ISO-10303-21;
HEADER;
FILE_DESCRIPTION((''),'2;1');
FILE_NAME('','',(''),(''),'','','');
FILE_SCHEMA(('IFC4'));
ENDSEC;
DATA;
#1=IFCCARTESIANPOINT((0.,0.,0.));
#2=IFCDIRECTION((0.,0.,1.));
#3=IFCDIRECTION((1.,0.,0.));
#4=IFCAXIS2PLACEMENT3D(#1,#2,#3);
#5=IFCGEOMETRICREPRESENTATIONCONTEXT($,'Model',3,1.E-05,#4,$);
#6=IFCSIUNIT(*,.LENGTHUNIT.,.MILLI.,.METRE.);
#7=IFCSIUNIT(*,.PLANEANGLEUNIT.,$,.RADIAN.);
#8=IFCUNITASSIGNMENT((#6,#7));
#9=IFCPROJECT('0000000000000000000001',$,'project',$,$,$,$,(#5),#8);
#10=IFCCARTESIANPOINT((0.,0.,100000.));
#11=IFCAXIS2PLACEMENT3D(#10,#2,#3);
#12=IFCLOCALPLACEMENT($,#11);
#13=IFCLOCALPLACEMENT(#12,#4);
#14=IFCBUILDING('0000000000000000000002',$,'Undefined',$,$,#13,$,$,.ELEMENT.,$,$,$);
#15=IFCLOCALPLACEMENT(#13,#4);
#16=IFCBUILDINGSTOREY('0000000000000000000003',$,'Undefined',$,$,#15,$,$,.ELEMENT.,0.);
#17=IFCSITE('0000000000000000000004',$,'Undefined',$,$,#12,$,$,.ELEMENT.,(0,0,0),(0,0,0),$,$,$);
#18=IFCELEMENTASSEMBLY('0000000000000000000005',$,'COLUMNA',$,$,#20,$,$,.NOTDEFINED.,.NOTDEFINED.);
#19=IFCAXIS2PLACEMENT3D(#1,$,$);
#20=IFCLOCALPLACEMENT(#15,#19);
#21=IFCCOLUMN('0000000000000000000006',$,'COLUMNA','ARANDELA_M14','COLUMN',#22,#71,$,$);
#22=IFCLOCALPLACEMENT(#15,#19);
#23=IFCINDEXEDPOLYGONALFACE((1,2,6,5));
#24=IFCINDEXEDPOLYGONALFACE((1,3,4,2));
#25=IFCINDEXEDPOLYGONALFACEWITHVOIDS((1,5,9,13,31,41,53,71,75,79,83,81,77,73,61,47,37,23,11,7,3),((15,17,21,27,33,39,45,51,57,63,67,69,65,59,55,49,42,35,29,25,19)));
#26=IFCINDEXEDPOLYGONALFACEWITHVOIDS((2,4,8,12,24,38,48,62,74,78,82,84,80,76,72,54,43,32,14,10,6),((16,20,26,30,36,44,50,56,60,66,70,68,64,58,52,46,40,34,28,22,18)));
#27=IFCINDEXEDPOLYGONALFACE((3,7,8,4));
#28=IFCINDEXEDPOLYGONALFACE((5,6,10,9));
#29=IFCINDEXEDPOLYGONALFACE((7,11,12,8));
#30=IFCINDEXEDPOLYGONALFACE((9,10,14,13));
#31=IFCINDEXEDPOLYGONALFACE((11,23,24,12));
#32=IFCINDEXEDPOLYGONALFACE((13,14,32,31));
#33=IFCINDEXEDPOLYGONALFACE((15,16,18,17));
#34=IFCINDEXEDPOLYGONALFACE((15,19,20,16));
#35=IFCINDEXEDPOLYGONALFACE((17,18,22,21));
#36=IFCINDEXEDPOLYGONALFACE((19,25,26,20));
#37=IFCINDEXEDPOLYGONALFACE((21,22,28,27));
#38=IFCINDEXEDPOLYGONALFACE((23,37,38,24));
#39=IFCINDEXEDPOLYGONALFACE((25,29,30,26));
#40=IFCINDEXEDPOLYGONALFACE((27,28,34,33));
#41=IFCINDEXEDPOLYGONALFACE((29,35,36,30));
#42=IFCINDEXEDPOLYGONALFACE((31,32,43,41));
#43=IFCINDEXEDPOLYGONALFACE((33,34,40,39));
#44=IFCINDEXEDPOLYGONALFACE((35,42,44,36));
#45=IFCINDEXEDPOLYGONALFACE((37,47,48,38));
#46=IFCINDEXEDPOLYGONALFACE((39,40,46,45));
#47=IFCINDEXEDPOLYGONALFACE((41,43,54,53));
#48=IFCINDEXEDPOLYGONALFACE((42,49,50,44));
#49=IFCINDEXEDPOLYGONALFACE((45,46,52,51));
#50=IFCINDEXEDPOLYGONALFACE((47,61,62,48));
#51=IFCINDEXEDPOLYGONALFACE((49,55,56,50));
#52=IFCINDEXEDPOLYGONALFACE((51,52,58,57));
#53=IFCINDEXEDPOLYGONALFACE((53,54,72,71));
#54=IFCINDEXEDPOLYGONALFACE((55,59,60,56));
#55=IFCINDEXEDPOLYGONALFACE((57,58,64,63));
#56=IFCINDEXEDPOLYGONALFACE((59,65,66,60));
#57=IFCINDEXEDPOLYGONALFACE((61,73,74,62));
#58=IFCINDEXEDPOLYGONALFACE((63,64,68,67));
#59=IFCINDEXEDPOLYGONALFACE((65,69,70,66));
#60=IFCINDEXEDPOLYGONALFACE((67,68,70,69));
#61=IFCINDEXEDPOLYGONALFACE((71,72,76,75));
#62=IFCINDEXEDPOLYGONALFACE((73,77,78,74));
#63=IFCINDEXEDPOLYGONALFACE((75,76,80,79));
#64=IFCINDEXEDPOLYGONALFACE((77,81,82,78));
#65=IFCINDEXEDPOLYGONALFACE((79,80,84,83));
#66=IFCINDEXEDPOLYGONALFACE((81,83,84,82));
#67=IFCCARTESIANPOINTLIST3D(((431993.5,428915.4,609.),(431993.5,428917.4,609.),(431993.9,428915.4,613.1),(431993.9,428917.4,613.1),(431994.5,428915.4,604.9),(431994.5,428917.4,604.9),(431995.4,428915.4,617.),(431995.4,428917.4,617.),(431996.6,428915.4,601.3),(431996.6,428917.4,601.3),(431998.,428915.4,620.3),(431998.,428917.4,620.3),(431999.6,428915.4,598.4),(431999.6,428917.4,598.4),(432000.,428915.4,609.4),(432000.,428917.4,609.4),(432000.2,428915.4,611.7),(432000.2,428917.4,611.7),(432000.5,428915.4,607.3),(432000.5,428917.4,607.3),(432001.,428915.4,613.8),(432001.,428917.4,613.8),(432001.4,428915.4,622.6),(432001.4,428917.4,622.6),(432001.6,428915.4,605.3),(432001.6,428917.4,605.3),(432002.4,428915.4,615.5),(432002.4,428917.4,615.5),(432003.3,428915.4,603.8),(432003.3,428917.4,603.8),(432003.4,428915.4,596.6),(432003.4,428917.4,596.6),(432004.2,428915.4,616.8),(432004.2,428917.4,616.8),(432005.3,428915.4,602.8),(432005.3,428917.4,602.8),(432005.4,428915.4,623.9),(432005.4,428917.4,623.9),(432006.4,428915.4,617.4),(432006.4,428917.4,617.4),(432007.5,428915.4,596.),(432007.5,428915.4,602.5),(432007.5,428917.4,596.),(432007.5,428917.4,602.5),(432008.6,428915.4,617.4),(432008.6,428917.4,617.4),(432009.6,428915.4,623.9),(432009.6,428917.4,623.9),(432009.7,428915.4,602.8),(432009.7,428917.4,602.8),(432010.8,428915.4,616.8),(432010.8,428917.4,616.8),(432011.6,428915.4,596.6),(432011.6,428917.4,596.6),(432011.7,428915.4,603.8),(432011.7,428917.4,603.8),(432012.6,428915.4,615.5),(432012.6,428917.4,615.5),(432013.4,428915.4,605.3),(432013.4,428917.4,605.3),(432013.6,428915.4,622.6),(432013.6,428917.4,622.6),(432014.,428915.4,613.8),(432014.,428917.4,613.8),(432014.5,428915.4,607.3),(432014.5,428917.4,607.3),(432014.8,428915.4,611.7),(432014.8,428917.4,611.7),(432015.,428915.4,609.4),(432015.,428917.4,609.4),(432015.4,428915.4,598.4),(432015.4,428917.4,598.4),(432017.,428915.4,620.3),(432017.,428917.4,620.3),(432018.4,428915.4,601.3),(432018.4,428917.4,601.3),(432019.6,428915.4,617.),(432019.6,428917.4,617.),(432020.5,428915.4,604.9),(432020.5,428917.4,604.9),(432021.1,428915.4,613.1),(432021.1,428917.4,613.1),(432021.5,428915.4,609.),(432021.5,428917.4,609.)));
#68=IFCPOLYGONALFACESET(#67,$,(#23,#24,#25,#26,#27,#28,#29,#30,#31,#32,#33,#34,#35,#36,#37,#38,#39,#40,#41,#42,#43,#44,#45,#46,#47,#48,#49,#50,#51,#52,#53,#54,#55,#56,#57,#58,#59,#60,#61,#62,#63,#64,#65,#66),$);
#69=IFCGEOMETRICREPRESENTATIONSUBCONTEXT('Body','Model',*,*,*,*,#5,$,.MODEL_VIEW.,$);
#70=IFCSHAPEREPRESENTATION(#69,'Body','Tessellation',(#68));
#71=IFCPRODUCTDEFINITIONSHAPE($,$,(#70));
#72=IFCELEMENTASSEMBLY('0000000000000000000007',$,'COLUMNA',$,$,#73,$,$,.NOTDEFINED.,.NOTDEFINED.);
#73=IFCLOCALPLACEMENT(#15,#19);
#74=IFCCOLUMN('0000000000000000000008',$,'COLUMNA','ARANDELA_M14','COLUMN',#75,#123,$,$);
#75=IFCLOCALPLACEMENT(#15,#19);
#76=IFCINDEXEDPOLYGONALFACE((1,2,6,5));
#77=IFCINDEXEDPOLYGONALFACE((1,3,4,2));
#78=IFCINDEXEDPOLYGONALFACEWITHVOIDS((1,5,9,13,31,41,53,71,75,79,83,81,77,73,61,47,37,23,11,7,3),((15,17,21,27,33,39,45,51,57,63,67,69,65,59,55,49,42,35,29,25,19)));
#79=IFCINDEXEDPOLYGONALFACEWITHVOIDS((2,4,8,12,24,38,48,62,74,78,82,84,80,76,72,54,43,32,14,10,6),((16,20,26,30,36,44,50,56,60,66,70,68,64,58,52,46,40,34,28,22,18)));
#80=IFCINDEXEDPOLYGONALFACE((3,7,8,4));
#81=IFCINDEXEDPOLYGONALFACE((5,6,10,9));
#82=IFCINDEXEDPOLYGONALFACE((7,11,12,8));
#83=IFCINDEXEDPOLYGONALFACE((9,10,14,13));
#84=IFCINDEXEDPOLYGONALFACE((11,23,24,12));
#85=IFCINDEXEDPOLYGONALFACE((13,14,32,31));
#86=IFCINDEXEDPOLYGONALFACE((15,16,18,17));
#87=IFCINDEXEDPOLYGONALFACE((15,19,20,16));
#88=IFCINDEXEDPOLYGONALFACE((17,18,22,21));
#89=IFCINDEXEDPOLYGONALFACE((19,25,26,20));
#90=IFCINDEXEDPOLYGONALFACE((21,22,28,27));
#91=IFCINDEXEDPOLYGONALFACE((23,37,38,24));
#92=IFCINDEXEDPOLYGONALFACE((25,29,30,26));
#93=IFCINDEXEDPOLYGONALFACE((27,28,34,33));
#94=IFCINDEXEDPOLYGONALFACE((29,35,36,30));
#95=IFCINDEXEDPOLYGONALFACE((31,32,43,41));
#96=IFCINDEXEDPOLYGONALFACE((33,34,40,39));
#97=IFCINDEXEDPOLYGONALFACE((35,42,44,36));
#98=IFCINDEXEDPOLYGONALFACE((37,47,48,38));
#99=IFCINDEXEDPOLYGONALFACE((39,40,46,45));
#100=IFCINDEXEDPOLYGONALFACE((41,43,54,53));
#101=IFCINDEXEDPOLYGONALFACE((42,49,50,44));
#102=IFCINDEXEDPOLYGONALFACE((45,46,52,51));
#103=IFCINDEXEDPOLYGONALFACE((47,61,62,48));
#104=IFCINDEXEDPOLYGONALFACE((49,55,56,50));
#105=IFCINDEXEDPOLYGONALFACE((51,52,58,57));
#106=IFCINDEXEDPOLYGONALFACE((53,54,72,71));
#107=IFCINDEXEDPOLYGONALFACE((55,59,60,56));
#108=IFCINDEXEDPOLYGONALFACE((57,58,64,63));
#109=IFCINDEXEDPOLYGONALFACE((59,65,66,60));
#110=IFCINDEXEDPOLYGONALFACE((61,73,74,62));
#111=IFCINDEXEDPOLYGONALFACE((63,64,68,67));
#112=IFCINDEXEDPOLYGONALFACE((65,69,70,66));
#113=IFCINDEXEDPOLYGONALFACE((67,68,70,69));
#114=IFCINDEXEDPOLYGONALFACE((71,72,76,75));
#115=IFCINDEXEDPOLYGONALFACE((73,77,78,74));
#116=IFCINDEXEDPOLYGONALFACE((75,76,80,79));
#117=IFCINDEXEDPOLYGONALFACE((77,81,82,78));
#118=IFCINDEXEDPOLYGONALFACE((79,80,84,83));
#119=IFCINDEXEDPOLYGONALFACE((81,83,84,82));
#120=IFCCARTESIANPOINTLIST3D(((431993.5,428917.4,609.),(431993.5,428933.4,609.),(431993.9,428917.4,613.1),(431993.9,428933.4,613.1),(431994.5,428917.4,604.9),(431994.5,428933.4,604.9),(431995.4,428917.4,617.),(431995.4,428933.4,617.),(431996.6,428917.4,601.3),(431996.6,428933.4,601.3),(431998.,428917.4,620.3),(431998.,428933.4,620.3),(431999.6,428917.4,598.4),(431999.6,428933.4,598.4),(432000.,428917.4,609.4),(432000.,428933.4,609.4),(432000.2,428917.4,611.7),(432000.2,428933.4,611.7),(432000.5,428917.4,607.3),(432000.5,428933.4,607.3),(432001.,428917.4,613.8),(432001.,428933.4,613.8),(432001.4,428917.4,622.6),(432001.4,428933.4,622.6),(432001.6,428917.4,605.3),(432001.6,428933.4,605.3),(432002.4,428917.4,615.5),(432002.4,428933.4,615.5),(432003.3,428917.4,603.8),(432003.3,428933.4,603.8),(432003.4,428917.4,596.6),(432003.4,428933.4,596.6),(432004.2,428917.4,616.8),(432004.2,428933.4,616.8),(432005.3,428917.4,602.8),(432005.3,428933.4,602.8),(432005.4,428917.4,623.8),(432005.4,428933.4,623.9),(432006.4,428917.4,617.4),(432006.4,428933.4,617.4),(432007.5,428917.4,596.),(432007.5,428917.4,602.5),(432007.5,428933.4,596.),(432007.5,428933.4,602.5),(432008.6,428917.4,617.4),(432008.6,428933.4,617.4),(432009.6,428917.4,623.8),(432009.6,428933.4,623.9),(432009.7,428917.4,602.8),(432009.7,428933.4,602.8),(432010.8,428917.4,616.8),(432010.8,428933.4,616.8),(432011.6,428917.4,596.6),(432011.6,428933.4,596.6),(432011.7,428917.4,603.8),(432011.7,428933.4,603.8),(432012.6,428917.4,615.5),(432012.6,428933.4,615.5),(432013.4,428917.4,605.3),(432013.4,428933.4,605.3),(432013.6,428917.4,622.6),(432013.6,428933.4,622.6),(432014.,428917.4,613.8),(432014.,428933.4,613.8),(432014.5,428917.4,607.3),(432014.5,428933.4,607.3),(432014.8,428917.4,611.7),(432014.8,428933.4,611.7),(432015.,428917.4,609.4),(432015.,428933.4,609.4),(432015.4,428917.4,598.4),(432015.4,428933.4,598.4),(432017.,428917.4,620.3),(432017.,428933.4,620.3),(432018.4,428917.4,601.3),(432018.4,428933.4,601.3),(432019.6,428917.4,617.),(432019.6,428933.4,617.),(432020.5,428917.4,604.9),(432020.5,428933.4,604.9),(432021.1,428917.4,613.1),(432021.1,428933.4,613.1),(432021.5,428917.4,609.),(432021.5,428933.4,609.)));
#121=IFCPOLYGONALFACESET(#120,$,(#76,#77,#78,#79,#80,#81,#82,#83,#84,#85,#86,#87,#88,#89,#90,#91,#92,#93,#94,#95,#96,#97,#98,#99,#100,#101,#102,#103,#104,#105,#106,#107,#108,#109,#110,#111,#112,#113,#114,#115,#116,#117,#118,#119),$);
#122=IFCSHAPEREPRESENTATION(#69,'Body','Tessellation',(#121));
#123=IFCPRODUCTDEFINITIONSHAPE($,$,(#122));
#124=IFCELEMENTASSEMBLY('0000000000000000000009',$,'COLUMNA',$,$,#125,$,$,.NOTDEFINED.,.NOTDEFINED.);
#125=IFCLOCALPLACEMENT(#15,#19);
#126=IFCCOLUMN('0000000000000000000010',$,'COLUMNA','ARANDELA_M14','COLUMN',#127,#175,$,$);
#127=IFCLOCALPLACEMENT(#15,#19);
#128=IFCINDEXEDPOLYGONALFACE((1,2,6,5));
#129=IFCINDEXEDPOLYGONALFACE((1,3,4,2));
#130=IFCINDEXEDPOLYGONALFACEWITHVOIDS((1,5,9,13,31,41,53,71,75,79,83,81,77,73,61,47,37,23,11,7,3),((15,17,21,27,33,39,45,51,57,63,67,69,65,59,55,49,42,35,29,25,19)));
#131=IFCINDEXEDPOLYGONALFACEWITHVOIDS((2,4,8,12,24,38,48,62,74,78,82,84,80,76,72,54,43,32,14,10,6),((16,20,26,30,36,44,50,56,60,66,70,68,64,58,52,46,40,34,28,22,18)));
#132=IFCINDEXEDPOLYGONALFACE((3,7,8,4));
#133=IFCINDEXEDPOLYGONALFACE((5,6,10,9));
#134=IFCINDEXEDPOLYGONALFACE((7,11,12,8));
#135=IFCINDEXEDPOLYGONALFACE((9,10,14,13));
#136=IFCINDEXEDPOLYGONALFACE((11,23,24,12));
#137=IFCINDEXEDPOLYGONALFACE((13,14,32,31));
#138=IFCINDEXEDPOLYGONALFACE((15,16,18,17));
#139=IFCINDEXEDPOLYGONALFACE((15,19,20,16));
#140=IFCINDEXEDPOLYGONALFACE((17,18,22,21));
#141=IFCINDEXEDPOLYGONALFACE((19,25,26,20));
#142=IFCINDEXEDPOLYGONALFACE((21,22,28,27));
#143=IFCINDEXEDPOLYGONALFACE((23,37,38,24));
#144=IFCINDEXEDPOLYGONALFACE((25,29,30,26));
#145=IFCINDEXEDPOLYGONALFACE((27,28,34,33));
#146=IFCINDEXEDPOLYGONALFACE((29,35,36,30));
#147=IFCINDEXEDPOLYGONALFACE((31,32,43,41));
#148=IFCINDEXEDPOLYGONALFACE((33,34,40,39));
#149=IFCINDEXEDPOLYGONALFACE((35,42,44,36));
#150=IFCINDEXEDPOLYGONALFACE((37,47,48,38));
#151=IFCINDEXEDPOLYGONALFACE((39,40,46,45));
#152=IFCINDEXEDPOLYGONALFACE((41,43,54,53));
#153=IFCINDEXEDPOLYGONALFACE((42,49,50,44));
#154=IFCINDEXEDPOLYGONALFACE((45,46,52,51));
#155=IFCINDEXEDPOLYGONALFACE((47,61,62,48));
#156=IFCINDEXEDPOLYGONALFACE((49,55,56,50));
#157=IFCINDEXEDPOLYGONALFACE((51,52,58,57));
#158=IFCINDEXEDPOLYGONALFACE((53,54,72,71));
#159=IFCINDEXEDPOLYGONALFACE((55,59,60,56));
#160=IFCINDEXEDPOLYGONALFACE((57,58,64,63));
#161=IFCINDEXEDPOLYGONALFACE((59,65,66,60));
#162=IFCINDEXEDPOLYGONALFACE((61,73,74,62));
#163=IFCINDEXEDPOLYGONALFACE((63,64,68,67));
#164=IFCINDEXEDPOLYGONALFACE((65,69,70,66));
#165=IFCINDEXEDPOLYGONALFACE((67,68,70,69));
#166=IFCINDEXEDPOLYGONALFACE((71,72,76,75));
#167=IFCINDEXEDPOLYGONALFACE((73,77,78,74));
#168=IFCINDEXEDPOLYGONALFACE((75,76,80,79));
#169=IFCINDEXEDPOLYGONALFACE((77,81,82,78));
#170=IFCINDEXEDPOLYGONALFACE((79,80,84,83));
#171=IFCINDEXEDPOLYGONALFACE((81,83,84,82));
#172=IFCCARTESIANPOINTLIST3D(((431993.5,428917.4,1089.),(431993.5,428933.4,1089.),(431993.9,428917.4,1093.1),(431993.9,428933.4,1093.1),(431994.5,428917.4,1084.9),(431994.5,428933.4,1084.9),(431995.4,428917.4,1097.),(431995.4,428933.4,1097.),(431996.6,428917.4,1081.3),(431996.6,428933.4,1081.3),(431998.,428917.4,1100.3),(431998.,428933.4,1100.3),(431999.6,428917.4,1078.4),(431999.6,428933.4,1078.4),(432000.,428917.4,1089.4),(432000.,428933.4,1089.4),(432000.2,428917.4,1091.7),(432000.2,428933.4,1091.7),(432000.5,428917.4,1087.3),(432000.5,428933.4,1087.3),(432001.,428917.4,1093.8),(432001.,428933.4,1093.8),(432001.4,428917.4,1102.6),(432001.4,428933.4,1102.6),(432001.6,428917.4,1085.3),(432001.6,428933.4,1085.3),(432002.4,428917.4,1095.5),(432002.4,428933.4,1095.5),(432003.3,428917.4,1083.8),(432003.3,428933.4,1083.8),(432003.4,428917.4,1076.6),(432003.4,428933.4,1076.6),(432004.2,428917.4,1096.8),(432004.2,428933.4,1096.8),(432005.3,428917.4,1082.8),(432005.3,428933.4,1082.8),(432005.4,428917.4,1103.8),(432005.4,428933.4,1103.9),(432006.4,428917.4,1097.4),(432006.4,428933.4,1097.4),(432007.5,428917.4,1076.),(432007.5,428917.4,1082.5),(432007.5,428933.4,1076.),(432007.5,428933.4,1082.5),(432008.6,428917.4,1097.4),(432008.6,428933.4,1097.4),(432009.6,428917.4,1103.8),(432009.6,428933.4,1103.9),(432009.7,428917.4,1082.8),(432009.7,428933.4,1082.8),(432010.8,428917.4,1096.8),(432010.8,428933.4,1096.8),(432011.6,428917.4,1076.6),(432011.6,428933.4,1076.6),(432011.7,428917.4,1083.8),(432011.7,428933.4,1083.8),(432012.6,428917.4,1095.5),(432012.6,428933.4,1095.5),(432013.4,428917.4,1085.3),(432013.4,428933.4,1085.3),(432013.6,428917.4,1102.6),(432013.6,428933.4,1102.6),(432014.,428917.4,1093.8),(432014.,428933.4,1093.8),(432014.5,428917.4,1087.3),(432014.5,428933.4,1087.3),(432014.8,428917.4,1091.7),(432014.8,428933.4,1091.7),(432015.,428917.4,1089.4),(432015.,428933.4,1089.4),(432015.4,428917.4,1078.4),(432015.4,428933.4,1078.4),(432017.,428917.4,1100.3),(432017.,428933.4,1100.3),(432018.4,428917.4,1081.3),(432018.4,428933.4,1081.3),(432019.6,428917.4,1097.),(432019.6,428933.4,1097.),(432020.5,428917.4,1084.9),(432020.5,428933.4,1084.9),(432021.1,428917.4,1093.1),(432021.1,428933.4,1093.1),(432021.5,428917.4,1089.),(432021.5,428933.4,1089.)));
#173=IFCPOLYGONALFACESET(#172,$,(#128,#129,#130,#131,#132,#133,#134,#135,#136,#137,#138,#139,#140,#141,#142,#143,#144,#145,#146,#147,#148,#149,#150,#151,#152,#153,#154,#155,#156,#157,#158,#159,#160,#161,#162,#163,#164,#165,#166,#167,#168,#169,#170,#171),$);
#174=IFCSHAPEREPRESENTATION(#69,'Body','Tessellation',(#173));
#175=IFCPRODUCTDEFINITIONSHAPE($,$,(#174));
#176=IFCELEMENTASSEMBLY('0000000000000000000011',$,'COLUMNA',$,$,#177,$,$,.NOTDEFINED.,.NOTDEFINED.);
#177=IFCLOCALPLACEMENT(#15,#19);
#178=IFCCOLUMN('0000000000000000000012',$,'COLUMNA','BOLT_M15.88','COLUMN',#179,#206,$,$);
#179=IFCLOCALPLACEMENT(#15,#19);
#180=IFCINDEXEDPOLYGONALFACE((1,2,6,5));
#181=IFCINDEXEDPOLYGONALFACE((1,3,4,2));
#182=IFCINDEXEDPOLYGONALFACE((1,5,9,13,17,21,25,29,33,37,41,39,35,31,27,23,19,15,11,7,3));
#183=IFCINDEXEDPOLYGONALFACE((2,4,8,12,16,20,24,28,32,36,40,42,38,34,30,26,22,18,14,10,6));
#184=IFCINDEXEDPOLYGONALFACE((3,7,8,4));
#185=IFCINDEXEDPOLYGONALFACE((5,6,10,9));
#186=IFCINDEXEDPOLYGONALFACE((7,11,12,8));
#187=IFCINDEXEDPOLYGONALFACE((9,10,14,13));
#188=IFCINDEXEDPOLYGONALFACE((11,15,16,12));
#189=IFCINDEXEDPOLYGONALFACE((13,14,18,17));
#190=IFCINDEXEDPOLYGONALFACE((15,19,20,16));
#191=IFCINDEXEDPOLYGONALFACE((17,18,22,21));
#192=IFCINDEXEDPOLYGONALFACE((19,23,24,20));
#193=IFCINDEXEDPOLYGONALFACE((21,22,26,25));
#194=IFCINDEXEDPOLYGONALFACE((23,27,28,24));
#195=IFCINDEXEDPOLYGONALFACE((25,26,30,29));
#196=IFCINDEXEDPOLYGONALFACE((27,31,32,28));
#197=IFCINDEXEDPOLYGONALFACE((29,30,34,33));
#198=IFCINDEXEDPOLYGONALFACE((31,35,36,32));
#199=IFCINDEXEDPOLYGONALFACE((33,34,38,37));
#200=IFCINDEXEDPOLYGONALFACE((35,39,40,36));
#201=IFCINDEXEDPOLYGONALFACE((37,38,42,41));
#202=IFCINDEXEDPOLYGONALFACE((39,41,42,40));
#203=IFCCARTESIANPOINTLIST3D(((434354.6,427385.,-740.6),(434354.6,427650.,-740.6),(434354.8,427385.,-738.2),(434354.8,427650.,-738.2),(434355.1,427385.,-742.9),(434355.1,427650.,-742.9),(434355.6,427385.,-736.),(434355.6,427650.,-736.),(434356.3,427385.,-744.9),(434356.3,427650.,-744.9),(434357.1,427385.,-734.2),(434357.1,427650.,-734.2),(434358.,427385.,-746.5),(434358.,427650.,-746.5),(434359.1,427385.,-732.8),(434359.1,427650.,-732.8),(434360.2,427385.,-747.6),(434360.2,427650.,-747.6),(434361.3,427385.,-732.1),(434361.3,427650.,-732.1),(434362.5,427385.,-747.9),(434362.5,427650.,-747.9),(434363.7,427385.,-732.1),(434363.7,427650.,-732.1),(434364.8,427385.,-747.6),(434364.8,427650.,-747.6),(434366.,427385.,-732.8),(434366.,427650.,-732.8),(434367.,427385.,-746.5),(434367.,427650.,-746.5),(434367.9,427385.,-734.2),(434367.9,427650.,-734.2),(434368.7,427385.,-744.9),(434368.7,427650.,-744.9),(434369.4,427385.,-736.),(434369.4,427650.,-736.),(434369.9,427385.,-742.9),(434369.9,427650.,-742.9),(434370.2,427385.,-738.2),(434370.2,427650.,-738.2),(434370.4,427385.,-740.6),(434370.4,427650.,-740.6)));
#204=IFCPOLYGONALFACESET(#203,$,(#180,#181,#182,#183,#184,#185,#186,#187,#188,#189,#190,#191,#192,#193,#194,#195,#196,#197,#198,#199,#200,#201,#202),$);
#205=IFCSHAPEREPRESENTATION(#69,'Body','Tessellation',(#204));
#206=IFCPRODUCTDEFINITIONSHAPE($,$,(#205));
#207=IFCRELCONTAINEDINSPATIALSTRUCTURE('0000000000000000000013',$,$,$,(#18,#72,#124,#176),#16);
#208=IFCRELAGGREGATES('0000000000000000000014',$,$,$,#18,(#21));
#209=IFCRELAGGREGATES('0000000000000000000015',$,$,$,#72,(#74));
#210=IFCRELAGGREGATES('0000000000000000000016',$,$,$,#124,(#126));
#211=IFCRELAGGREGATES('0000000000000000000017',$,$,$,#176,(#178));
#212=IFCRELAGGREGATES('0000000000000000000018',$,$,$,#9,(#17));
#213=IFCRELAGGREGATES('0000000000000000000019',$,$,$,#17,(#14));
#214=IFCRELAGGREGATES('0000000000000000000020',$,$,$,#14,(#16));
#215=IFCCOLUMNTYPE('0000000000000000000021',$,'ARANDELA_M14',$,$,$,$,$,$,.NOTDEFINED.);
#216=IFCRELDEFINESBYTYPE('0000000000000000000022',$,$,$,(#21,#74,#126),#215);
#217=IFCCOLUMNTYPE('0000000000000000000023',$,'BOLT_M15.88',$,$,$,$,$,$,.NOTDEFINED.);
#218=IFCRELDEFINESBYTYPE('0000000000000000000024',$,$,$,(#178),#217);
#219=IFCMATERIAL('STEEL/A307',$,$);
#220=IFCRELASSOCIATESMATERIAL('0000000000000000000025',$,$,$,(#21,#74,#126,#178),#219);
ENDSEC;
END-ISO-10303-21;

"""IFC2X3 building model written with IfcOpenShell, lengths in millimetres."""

from ifc_helpers import new_model, si_unit, frame, origin_with_axes, origin_2d_with_axis, place, context, subcontext, project, spatial, circle, hollow_circle, extrude, material, type_object, element, aggregate, save


model = new_model("IFC2X3")

# Units and contexts
model_context = context("Model", 3, precision=1e-05, world=origin_with_axes())
body_context = subcontext(model_context, "Body", "Model", "MODEL_VIEW")
ifc_project = project(units=[si_unit("LENGTHUNIT", "METRE", prefix="MILLI"), si_unit("PLANEANGLEUNIT", "RADIAN")], contexts=[model_context])

# Site, building, storey
site_placement = place(None, frame((0.0, 0.0, 100000.0), z_axis=(0.0, 0.0, 1.0), x_axis=(1.0, 0.0, 0.0)))
site = spatial("IfcSite", under=ifc_project, at=site_placement, Name="Undefined", CompositionType="ELEMENT", RefLatitude=(0, 0, 0), RefLongitude=(0, 0, 0))
building_placement = place(site_placement, origin_with_axes())
building = spatial("IfcBuilding", under=site, at=building_placement, Name="Undefined", CompositionType="ELEMENT")
storey_placement = place(building_placement, origin_with_axes())
storey = spatial("IfcBuildingStorey", under=building, at=storey_placement, Name="Undefined", CompositionType="ELEMENT", Elevation=0.0)

# Element assemblies, columns
ifc_material_1 = material(Name="STEEL/A307")
column_type_1 = type_object("IfcColumnType", Name="ARANDELA_M14", PredefinedType="NOTDEFINED")
assembly_1_placement = place(storey_placement, origin_with_axes())
assembly_1 = element("IfcElementAssembly", 1, at=assembly_1_placement, inside=storey, Name="COLUMNA", AssemblyPlace="NOTDEFINED", PredefinedType="NOTDEFINED")
column_1_placement = place(assembly_1_placement, frame((432007.5, 428915.4, 610.0), z_axis=(0.0, 1.0, 0.000285), x_axis=(1.0, 0.0, 0.0)))
column_1 = element("IfcColumn", 2, at=column_1_placement, type_object=column_type_1, material=ifc_material_1, Name="COLUMNA", Description="ARANDELA_M14", ObjectType="COLUMN", context=body_context, shape_type="SweptSolid", body=[
    extrude(hollow_circle(Radius=14.0, WallThickness=6.5, at=origin_2d_with_axis()), frame((0.0, 0.0, 2.0), z_axis=(0.0, 0.0, -1.0), x_axis=(0.0, 1.0, 0.0)), (0.0, 0.0, 1.0), 2.0),
])
aggregate(assembly_1, [column_1])
assembly_2_placement = place(storey_placement, origin_with_axes())
assembly_2 = element("IfcElementAssembly", 3, at=assembly_2_placement, inside=storey, Name="COLUMNA", AssemblyPlace="NOTDEFINED", PredefinedType="NOTDEFINED")
column_2_placement = place(assembly_2_placement, frame((432007.5, 428917.4, 610.0), z_axis=(0.0, 1.0, 0.000285), x_axis=(1.0, 0.0, 0.0)))
column_2 = element("IfcColumn", 4, at=column_2_placement, type_object=column_type_1, material=ifc_material_1, Name="COLUMNA", Description="ARANDELA_M14", ObjectType="COLUMN", context=body_context, shape_type="SweptSolid", body=[
    extrude(hollow_circle(Radius=14.0, WallThickness=6.5, at=origin_2d_with_axis()), frame((0.0, 0.0, 16.0), z_axis=(0.0, 0.0, -1.0), x_axis=(0.0, 1.0, 0.0)), (0.0, 0.0, 1.0), 16.0),
])
aggregate(assembly_2, [column_2])
assembly_3_placement = place(storey_placement, origin_with_axes())
assembly_3 = element("IfcElementAssembly", 5, at=assembly_3_placement, inside=storey, Name="COLUMNA", AssemblyPlace="NOTDEFINED", PredefinedType="NOTDEFINED")
column_3_placement = place(assembly_3_placement, frame((432007.5, 428917.4, 1090.0), z_axis=(0.0, 1.0, 0.000285), x_axis=(1.0, 0.0, 0.0)))
column_3 = element("IfcColumn", 6, at=column_3_placement, type_object=column_type_1, material=ifc_material_1, Name="COLUMNA", Description="ARANDELA_M14", ObjectType="COLUMN", context=body_context, shape_type="SweptSolid", body=[
    extrude(hollow_circle(Radius=14.0, WallThickness=6.5, at=origin_2d_with_axis()), frame((0.0, 0.0, 16.0), z_axis=(0.0, 0.0, -1.0), x_axis=(0.0, 1.0, 0.0)), (0.0, 0.0, 1.0), 16.0),
])
aggregate(assembly_3, [column_3])
assembly_4_placement = place(storey_placement, origin_with_axes())
assembly_4 = element("IfcElementAssembly", 7, at=assembly_4_placement, inside=storey, Name="COLUMNA", AssemblyPlace="NOTDEFINED", PredefinedType="NOTDEFINED")
column_type_2 = type_object("IfcColumnType", Name="BOLT_M15.88", PredefinedType="NOTDEFINED")
column_4_placement = place(assembly_4_placement, frame((434362.5, 427650.0, -740.0), z_axis=(0.0, -1.0, -0.000003), x_axis=(-1.0, 0.0, 0.0)))
column_4 = element("IfcColumn", 8, at=column_4_placement, type_object=column_type_2, material=ifc_material_1, Name="COLUMNA", Description="BOLT_M15.88", ObjectType="COLUMN", context=body_context, shape_type="SweptSolid", body=[
    extrude(circle(Radius=7.9, at=origin_2d_with_axis()), frame((0.0, 0.0, 265.0), z_axis=(0.0, 0.0, -1.0), x_axis=(0.0, 1.0, 0.0)), (0.0, 0.0, 1.0), 265.0),
])
aggregate(assembly_4, [column_4])

save(model, "model.ifc")
